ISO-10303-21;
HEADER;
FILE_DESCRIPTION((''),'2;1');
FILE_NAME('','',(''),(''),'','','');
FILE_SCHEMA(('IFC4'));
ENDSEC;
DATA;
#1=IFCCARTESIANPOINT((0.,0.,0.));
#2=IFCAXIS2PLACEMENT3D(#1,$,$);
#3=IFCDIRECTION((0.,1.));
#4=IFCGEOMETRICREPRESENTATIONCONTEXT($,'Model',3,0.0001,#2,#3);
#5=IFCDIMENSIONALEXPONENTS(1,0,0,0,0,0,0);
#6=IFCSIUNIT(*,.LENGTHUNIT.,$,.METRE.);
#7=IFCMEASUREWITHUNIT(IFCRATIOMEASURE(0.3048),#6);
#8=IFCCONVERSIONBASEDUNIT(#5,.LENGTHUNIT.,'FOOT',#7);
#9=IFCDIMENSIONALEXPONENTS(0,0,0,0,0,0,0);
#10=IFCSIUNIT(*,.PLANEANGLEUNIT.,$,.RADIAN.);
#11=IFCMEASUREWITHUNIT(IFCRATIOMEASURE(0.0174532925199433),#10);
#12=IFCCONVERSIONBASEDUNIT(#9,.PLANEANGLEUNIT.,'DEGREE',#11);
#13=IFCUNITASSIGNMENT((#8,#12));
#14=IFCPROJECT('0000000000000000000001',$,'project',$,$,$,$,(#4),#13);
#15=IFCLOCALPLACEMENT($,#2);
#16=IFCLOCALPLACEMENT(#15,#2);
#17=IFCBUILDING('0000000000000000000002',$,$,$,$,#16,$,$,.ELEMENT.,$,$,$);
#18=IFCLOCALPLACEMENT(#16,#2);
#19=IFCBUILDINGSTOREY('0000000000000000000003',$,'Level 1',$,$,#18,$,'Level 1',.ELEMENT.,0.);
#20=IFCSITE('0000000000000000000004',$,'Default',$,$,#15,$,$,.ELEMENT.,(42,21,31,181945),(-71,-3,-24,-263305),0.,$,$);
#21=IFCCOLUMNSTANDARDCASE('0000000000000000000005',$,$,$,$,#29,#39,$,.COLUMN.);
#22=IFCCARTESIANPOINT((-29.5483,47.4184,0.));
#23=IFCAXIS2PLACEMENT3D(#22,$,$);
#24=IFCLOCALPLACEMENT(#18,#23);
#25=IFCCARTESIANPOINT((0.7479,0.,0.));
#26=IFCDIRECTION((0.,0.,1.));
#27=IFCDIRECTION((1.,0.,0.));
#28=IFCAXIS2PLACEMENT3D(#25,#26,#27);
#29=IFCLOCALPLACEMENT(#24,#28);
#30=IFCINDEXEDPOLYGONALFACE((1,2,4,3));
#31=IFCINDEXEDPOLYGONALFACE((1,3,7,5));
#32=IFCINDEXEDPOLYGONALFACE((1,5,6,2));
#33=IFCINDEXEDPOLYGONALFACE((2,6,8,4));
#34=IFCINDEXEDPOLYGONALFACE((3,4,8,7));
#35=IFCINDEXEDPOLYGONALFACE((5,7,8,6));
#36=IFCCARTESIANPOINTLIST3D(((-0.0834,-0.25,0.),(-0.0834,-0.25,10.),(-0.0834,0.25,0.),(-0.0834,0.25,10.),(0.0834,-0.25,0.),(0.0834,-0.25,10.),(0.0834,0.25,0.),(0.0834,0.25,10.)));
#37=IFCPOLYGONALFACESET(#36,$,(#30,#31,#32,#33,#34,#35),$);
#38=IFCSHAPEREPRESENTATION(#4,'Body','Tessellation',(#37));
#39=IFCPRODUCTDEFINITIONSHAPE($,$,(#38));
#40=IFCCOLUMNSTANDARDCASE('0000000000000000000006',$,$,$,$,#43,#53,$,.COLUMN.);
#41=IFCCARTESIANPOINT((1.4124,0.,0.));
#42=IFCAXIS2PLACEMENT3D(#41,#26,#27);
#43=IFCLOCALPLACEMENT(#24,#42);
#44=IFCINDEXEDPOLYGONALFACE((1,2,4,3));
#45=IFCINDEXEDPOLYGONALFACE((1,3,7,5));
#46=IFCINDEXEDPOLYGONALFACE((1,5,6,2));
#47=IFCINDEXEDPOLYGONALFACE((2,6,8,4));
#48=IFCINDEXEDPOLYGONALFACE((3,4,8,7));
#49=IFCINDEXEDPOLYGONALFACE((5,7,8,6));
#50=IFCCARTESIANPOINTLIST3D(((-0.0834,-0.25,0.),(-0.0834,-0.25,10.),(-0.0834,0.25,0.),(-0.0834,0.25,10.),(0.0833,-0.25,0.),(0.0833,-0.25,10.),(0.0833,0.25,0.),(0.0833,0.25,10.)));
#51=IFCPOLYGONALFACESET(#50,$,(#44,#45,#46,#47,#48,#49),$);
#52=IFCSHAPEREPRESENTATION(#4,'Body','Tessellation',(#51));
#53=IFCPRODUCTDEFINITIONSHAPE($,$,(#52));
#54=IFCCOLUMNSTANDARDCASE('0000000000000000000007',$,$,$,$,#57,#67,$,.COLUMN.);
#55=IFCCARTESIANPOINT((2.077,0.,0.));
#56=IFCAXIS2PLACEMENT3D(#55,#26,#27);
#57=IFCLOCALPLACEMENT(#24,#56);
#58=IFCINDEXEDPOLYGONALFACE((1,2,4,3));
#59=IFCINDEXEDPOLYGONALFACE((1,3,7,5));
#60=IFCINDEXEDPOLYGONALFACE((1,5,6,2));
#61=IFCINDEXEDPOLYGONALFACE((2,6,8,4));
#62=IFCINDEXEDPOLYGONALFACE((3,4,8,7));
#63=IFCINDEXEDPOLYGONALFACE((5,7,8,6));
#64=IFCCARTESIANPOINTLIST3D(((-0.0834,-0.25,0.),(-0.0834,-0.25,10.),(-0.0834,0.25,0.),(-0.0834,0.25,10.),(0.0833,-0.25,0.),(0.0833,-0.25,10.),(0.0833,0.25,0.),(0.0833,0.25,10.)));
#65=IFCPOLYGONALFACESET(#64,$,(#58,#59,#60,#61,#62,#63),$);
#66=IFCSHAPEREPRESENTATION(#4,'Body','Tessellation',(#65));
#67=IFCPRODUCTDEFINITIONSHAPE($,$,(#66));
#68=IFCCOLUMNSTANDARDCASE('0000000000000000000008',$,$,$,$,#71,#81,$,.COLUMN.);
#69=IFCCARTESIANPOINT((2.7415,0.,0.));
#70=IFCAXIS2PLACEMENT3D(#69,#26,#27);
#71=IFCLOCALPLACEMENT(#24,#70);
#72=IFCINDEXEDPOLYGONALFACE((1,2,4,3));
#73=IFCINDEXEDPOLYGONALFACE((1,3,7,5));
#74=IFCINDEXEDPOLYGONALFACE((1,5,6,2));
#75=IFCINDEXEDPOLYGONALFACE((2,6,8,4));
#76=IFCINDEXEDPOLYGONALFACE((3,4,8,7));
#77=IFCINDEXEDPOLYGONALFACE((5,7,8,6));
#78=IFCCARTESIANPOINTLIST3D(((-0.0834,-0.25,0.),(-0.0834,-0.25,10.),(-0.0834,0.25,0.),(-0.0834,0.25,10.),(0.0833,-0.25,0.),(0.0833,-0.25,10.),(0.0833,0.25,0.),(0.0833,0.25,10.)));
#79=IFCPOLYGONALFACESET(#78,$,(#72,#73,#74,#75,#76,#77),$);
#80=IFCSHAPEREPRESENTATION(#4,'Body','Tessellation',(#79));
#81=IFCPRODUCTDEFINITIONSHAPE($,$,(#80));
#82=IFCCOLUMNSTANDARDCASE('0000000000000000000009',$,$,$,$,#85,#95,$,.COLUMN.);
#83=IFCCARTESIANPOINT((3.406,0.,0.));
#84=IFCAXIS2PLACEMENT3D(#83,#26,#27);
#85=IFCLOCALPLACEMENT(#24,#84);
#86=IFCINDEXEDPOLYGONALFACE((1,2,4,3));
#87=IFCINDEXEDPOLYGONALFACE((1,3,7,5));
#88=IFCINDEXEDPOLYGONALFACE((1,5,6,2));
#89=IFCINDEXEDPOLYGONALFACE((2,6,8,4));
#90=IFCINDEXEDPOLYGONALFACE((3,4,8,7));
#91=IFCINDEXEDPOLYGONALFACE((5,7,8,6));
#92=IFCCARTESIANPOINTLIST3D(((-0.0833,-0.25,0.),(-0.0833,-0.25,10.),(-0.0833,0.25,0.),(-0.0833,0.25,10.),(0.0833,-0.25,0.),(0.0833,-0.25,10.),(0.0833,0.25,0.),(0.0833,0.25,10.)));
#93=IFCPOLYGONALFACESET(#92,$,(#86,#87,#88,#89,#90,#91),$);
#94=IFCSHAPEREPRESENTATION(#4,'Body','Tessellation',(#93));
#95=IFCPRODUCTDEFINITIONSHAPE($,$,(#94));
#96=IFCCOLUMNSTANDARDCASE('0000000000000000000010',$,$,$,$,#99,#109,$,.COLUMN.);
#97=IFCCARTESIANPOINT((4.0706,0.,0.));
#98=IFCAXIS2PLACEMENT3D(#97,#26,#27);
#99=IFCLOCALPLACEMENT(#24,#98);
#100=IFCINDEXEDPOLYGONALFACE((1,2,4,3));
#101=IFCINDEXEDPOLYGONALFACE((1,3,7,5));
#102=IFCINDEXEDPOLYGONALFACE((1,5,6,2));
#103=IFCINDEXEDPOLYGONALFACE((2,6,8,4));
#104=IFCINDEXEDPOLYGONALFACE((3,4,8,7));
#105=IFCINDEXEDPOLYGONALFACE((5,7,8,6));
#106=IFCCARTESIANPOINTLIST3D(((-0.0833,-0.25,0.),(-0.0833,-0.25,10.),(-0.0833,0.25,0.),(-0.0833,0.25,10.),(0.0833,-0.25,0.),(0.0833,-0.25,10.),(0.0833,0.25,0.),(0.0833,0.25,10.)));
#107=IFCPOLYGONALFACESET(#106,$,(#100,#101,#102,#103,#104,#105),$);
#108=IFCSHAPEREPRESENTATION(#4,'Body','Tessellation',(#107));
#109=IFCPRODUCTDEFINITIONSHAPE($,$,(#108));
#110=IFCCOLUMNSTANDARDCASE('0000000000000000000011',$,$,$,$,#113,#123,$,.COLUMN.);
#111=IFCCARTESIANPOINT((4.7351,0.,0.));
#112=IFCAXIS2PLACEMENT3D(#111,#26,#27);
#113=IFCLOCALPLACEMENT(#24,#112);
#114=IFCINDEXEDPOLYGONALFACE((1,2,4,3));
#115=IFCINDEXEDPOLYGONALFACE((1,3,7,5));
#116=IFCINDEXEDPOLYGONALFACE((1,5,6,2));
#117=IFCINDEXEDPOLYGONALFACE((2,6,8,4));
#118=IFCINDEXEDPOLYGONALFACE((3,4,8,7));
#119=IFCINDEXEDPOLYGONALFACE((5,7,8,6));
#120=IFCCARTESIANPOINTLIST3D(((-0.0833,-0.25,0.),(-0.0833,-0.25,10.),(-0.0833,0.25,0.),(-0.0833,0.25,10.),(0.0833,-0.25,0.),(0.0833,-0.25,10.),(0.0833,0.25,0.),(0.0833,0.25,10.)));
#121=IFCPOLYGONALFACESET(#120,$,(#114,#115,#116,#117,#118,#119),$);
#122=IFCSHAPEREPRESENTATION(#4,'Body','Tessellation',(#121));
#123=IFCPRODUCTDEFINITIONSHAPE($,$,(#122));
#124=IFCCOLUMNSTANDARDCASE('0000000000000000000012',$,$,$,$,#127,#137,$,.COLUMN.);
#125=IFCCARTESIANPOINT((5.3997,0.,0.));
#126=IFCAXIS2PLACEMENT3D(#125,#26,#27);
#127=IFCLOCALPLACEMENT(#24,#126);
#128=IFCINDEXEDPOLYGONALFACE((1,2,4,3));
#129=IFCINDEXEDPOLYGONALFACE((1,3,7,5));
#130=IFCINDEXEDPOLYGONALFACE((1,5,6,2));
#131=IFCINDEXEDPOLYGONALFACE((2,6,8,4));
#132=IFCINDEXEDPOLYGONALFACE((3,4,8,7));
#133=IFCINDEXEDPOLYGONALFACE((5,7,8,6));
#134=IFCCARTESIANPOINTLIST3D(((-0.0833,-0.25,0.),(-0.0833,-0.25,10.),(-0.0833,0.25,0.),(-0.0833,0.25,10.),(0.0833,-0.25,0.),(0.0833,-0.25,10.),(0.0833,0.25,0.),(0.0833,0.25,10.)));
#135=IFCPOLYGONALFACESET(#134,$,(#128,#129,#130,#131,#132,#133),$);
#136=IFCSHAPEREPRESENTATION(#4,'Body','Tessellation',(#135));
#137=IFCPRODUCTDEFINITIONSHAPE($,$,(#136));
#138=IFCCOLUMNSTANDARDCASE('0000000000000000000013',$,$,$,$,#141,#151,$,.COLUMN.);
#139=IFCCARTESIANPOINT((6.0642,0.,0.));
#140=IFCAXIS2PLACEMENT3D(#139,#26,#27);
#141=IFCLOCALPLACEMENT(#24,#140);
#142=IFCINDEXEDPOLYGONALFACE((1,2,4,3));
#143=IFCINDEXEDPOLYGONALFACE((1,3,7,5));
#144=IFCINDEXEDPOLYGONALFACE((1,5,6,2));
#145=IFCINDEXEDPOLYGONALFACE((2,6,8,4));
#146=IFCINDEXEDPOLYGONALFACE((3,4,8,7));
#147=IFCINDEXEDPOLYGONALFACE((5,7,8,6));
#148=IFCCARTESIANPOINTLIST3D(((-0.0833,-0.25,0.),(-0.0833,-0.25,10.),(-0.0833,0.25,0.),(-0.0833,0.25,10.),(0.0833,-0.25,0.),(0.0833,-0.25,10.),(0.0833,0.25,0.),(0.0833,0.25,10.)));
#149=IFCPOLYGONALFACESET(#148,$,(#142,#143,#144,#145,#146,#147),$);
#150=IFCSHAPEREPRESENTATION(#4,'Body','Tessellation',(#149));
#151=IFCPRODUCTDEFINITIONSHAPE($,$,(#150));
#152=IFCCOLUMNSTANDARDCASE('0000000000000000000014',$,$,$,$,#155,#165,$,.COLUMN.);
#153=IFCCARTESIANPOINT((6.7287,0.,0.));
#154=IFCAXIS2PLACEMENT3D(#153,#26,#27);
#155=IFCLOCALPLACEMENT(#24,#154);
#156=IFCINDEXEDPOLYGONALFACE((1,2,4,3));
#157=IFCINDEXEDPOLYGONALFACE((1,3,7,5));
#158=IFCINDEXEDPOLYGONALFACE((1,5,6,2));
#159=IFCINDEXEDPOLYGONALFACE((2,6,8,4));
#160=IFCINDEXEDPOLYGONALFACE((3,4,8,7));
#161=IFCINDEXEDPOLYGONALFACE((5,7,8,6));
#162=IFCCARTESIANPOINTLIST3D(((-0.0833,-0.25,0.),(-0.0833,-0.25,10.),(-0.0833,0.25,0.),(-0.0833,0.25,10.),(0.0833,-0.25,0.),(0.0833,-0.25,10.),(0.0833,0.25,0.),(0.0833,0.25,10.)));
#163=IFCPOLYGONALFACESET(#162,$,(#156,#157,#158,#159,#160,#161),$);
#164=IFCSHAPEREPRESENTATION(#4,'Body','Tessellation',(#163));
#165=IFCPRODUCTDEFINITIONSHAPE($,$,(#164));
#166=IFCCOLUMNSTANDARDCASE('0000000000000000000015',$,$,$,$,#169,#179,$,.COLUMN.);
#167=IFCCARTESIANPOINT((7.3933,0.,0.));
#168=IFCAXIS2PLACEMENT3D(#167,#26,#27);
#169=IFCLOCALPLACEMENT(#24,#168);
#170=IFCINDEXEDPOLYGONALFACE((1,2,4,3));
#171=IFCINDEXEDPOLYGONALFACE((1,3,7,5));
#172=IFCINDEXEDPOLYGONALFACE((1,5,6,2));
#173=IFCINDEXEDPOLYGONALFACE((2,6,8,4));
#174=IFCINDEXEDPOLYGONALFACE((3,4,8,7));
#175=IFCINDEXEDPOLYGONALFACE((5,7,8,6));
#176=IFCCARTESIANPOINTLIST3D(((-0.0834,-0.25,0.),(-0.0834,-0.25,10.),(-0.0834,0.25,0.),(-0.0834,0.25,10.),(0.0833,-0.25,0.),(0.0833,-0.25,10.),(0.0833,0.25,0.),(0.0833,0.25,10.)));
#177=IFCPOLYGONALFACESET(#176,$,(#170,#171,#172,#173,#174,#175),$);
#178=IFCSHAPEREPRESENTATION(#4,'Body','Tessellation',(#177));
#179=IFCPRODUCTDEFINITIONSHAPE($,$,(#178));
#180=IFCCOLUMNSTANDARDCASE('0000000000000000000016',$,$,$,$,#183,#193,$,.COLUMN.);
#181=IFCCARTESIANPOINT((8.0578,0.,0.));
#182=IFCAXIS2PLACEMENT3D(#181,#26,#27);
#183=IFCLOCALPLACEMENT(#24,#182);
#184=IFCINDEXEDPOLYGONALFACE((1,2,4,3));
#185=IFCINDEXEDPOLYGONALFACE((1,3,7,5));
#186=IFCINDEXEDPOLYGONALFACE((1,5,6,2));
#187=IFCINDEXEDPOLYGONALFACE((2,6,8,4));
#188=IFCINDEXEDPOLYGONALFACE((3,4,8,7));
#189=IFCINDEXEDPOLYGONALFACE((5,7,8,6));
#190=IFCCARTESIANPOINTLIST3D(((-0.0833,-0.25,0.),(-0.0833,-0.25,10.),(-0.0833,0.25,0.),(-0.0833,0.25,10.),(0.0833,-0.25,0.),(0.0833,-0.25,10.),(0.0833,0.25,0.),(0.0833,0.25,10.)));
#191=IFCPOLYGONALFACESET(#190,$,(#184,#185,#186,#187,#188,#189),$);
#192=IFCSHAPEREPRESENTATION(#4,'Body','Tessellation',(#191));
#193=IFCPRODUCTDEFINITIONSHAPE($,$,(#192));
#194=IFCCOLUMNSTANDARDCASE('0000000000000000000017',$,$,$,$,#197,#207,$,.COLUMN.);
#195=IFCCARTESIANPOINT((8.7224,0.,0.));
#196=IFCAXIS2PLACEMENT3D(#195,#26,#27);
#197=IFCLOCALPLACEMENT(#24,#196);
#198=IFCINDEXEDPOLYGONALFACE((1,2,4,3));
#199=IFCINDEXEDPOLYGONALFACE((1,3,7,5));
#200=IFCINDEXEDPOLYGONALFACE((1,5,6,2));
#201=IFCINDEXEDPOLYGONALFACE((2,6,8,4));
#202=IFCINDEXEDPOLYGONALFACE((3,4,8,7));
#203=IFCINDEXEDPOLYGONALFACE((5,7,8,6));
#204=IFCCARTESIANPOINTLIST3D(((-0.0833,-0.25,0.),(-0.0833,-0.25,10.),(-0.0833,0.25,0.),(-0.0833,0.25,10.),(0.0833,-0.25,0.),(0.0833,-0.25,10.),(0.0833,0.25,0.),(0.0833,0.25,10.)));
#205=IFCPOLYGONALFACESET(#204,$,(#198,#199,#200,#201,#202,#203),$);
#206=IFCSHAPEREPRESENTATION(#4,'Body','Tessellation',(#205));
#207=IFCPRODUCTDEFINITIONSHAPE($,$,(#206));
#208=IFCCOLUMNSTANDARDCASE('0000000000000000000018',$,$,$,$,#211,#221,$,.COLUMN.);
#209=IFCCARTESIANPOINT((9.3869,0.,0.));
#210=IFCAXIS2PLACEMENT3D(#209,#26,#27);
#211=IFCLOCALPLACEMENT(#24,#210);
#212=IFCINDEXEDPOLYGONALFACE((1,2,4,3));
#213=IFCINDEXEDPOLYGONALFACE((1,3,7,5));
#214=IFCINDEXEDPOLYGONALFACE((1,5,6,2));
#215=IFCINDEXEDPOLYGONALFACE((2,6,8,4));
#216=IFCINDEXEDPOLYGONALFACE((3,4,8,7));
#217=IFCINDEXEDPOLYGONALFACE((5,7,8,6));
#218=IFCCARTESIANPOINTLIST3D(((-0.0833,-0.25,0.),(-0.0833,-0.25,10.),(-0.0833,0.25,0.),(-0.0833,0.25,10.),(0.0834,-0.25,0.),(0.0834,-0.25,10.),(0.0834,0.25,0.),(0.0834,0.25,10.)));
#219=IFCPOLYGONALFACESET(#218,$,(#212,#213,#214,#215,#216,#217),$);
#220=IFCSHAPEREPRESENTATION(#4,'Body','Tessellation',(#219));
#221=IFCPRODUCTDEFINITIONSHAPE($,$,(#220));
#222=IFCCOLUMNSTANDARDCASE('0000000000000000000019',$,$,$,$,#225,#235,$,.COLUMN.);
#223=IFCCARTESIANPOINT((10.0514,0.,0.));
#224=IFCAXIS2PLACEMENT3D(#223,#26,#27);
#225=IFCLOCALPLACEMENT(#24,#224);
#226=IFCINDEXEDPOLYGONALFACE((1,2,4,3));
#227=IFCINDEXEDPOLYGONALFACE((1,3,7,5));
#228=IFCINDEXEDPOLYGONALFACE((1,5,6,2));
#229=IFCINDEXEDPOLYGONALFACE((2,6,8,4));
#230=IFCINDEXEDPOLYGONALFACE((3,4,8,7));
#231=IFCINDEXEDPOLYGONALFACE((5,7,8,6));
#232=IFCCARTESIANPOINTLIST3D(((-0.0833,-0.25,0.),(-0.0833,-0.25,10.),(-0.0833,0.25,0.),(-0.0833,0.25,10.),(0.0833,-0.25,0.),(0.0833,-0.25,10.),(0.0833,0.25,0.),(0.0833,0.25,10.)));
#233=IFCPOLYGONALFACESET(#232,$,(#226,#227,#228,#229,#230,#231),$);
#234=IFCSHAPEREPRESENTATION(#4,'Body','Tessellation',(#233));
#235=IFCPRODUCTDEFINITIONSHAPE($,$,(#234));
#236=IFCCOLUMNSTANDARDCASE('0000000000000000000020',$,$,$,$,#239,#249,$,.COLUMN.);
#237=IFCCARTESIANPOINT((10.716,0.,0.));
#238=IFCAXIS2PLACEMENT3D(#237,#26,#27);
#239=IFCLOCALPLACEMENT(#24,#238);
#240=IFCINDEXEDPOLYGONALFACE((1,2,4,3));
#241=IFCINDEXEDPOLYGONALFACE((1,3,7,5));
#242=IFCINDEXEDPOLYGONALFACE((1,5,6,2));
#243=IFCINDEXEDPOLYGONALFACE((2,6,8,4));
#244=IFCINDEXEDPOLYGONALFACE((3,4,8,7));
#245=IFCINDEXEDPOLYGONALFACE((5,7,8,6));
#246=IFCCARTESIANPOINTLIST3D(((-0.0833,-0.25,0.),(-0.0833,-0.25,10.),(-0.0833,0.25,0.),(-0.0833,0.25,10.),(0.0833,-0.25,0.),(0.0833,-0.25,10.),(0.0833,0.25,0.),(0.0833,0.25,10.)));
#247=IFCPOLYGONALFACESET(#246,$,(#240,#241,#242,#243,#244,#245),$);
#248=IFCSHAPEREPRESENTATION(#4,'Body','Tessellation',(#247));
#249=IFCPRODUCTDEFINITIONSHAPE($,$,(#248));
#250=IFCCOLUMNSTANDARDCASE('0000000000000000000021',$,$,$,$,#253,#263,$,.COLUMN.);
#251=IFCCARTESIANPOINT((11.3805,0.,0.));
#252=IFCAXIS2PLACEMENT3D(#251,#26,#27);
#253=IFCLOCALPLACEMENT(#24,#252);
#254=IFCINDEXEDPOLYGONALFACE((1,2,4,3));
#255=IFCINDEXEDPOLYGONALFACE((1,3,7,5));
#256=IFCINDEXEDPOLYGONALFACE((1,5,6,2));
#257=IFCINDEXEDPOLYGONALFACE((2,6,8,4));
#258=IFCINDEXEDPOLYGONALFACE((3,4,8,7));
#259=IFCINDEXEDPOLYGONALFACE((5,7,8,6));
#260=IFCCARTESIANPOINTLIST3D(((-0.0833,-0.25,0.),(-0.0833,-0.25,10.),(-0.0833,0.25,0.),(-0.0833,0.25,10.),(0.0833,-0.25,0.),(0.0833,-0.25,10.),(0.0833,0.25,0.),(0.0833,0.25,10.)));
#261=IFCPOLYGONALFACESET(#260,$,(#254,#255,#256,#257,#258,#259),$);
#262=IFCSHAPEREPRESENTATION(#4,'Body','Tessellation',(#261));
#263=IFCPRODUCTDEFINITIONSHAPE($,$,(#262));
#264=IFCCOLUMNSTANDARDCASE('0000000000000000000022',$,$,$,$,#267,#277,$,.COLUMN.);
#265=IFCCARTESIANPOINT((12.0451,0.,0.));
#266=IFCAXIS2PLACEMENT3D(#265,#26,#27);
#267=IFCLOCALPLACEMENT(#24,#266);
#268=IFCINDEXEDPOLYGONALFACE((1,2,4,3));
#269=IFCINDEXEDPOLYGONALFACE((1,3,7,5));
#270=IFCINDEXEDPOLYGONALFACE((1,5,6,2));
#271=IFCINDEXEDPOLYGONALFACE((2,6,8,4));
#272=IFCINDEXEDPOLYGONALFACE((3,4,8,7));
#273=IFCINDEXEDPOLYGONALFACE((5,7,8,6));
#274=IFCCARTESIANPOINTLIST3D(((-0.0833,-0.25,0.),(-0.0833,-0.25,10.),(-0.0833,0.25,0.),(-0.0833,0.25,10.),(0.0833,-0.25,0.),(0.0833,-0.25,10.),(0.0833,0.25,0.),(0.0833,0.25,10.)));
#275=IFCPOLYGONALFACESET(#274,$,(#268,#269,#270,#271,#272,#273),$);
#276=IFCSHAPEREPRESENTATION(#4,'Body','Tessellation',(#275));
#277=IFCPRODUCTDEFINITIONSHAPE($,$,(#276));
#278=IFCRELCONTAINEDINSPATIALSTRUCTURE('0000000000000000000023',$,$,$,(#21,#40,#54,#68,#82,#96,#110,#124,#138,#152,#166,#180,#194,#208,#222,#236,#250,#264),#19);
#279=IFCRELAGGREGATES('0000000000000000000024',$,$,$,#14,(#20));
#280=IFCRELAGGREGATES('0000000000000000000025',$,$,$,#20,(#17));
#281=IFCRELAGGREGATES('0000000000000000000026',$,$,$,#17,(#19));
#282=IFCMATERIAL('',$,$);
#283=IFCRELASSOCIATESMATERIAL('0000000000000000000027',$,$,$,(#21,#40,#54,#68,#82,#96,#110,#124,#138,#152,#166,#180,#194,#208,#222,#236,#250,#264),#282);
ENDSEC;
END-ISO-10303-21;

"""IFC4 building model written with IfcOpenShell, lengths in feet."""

from ifc_helpers import new_model, entity, si_unit, converted_unit, direction, frame, origin, place, context, project, spatial, rectangle, extrude, material, element, save


model = new_model("IFC4")

# Units and contexts
model_context = context("Model", 3, precision=0.0001, world=origin(), true_north=direction((0.0, 1.0)))
ifc_project = project(units=[converted_unit("LENGTHUNIT", "FOOT", entity("IfcRatioMeasure", 0.3048), si_unit("LENGTHUNIT", "METRE"), dimensions=[1, 0, 0, 0, 0, 0, 0]), converted_unit("PLANEANGLEUNIT", "DEGREE", entity("IfcRatioMeasure", 0.0174532925199433), si_unit("PLANEANGLEUNIT", "RADIAN"), dimensions=[0, 0, 0, 0, 0, 0, 0])], contexts=[model_context])

# Site, building, storey
site_placement = place(None, origin())
site = spatial("IfcSite", under=ifc_project, at=site_placement, Name="Default", CompositionType="ELEMENT", RefLatitude=(42, 21, 31, 181945), RefLongitude=(-71, -3, -24, -263305), RefElevation=0.0)
building_placement = place(site_placement, origin())
building = spatial("IfcBuilding", under=site, at=building_placement, CompositionType="ELEMENT")
storey_placement = place(building_placement, origin())
storey = spatial("IfcBuildingStorey", under=building, at=storey_placement, Name="Level 1", LongName="Level 1", CompositionType="ELEMENT", Elevation=0.0)

# Columns
ifc_material_1 = material(Name="")
wall_1_placement = place(storey_placement, frame((-29.5483, 47.4184, 0.0)))
for number, where, z_axis, x_axis in (
    (1, (0.7479, 0.0, 0.0), (0.0, 0.0, 1.0), (1.0, 0.0, 0.0)),
    (2, (1.4124, 0.0, 0.0), (0.0, 0.0, 1.0), (1.0, 0.0, 0.0)),
    (3, (2.077, 0.0, 0.0), (0.0, 0.0, 1.0), (1.0, 0.0, 0.0)),
    (4, (2.7415, 0.0, 0.0), (0.0, 0.0, 1.0), (1.0, 0.0, 0.0)),
    (5, (3.406, 0.0, 0.0), (0.0, 0.0, 1.0), (1.0, 0.0, 0.0)),
    (6, (4.0706, 0.0, 0.0), (0.0, 0.0, 1.0), (1.0, 0.0, 0.0)),
    (7, (4.7351, 0.0, 0.0), (0.0, 0.0, 1.0), (1.0, 0.0, 0.0)),
    (8, (5.3997, 0.0, 0.0), (0.0, 0.0, 1.0), (1.0, 0.0, 0.0)),
    (9, (6.0642, 0.0, 0.0), (0.0, 0.0, 1.0), (1.0, 0.0, 0.0)),
    (10, (6.7287, 0.0, 0.0), (0.0, 0.0, 1.0), (1.0, 0.0, 0.0)),
    (11, (7.3933, 0.0, 0.0), (0.0, 0.0, 1.0), (1.0, 0.0, 0.0)),
    (12, (8.0578, 0.0, 0.0), (0.0, 0.0, 1.0), (1.0, 0.0, 0.0)),
    (13, (8.7224, 0.0, 0.0), (0.0, 0.0, 1.0), (1.0, 0.0, 0.0)),
    (14, (9.3869, 0.0, 0.0), (0.0, 0.0, 1.0), (1.0, 0.0, 0.0)),
    (15, (10.0514, 0.0, 0.0), (0.0, 0.0, 1.0), (1.0, 0.0, 0.0)),
    (16, (10.716, 0.0, 0.0), (0.0, 0.0, 1.0), (1.0, 0.0, 0.0)),
    (17, (11.3805, 0.0, 0.0), (0.0, 0.0, 1.0), (1.0, 0.0, 0.0)),
    (18, (12.0451, 0.0, 0.0), (0.0, 0.0, 1.0), (1.0, 0.0, 0.0)),
):
    element("IfcColumnStandardCase", number, at=place(wall_1_placement, frame(where, z_axis=z_axis, x_axis=x_axis)), inside=storey, material=ifc_material_1, PredefinedType="COLUMN", context=model_context, shape_type="SweptSolid", body=[
        extrude(rectangle(XDim=0.1667, YDim=0.5), origin(), (0.0, 0.0, 1.0), 10.0),
    ])

save(model, "model.ifc")
